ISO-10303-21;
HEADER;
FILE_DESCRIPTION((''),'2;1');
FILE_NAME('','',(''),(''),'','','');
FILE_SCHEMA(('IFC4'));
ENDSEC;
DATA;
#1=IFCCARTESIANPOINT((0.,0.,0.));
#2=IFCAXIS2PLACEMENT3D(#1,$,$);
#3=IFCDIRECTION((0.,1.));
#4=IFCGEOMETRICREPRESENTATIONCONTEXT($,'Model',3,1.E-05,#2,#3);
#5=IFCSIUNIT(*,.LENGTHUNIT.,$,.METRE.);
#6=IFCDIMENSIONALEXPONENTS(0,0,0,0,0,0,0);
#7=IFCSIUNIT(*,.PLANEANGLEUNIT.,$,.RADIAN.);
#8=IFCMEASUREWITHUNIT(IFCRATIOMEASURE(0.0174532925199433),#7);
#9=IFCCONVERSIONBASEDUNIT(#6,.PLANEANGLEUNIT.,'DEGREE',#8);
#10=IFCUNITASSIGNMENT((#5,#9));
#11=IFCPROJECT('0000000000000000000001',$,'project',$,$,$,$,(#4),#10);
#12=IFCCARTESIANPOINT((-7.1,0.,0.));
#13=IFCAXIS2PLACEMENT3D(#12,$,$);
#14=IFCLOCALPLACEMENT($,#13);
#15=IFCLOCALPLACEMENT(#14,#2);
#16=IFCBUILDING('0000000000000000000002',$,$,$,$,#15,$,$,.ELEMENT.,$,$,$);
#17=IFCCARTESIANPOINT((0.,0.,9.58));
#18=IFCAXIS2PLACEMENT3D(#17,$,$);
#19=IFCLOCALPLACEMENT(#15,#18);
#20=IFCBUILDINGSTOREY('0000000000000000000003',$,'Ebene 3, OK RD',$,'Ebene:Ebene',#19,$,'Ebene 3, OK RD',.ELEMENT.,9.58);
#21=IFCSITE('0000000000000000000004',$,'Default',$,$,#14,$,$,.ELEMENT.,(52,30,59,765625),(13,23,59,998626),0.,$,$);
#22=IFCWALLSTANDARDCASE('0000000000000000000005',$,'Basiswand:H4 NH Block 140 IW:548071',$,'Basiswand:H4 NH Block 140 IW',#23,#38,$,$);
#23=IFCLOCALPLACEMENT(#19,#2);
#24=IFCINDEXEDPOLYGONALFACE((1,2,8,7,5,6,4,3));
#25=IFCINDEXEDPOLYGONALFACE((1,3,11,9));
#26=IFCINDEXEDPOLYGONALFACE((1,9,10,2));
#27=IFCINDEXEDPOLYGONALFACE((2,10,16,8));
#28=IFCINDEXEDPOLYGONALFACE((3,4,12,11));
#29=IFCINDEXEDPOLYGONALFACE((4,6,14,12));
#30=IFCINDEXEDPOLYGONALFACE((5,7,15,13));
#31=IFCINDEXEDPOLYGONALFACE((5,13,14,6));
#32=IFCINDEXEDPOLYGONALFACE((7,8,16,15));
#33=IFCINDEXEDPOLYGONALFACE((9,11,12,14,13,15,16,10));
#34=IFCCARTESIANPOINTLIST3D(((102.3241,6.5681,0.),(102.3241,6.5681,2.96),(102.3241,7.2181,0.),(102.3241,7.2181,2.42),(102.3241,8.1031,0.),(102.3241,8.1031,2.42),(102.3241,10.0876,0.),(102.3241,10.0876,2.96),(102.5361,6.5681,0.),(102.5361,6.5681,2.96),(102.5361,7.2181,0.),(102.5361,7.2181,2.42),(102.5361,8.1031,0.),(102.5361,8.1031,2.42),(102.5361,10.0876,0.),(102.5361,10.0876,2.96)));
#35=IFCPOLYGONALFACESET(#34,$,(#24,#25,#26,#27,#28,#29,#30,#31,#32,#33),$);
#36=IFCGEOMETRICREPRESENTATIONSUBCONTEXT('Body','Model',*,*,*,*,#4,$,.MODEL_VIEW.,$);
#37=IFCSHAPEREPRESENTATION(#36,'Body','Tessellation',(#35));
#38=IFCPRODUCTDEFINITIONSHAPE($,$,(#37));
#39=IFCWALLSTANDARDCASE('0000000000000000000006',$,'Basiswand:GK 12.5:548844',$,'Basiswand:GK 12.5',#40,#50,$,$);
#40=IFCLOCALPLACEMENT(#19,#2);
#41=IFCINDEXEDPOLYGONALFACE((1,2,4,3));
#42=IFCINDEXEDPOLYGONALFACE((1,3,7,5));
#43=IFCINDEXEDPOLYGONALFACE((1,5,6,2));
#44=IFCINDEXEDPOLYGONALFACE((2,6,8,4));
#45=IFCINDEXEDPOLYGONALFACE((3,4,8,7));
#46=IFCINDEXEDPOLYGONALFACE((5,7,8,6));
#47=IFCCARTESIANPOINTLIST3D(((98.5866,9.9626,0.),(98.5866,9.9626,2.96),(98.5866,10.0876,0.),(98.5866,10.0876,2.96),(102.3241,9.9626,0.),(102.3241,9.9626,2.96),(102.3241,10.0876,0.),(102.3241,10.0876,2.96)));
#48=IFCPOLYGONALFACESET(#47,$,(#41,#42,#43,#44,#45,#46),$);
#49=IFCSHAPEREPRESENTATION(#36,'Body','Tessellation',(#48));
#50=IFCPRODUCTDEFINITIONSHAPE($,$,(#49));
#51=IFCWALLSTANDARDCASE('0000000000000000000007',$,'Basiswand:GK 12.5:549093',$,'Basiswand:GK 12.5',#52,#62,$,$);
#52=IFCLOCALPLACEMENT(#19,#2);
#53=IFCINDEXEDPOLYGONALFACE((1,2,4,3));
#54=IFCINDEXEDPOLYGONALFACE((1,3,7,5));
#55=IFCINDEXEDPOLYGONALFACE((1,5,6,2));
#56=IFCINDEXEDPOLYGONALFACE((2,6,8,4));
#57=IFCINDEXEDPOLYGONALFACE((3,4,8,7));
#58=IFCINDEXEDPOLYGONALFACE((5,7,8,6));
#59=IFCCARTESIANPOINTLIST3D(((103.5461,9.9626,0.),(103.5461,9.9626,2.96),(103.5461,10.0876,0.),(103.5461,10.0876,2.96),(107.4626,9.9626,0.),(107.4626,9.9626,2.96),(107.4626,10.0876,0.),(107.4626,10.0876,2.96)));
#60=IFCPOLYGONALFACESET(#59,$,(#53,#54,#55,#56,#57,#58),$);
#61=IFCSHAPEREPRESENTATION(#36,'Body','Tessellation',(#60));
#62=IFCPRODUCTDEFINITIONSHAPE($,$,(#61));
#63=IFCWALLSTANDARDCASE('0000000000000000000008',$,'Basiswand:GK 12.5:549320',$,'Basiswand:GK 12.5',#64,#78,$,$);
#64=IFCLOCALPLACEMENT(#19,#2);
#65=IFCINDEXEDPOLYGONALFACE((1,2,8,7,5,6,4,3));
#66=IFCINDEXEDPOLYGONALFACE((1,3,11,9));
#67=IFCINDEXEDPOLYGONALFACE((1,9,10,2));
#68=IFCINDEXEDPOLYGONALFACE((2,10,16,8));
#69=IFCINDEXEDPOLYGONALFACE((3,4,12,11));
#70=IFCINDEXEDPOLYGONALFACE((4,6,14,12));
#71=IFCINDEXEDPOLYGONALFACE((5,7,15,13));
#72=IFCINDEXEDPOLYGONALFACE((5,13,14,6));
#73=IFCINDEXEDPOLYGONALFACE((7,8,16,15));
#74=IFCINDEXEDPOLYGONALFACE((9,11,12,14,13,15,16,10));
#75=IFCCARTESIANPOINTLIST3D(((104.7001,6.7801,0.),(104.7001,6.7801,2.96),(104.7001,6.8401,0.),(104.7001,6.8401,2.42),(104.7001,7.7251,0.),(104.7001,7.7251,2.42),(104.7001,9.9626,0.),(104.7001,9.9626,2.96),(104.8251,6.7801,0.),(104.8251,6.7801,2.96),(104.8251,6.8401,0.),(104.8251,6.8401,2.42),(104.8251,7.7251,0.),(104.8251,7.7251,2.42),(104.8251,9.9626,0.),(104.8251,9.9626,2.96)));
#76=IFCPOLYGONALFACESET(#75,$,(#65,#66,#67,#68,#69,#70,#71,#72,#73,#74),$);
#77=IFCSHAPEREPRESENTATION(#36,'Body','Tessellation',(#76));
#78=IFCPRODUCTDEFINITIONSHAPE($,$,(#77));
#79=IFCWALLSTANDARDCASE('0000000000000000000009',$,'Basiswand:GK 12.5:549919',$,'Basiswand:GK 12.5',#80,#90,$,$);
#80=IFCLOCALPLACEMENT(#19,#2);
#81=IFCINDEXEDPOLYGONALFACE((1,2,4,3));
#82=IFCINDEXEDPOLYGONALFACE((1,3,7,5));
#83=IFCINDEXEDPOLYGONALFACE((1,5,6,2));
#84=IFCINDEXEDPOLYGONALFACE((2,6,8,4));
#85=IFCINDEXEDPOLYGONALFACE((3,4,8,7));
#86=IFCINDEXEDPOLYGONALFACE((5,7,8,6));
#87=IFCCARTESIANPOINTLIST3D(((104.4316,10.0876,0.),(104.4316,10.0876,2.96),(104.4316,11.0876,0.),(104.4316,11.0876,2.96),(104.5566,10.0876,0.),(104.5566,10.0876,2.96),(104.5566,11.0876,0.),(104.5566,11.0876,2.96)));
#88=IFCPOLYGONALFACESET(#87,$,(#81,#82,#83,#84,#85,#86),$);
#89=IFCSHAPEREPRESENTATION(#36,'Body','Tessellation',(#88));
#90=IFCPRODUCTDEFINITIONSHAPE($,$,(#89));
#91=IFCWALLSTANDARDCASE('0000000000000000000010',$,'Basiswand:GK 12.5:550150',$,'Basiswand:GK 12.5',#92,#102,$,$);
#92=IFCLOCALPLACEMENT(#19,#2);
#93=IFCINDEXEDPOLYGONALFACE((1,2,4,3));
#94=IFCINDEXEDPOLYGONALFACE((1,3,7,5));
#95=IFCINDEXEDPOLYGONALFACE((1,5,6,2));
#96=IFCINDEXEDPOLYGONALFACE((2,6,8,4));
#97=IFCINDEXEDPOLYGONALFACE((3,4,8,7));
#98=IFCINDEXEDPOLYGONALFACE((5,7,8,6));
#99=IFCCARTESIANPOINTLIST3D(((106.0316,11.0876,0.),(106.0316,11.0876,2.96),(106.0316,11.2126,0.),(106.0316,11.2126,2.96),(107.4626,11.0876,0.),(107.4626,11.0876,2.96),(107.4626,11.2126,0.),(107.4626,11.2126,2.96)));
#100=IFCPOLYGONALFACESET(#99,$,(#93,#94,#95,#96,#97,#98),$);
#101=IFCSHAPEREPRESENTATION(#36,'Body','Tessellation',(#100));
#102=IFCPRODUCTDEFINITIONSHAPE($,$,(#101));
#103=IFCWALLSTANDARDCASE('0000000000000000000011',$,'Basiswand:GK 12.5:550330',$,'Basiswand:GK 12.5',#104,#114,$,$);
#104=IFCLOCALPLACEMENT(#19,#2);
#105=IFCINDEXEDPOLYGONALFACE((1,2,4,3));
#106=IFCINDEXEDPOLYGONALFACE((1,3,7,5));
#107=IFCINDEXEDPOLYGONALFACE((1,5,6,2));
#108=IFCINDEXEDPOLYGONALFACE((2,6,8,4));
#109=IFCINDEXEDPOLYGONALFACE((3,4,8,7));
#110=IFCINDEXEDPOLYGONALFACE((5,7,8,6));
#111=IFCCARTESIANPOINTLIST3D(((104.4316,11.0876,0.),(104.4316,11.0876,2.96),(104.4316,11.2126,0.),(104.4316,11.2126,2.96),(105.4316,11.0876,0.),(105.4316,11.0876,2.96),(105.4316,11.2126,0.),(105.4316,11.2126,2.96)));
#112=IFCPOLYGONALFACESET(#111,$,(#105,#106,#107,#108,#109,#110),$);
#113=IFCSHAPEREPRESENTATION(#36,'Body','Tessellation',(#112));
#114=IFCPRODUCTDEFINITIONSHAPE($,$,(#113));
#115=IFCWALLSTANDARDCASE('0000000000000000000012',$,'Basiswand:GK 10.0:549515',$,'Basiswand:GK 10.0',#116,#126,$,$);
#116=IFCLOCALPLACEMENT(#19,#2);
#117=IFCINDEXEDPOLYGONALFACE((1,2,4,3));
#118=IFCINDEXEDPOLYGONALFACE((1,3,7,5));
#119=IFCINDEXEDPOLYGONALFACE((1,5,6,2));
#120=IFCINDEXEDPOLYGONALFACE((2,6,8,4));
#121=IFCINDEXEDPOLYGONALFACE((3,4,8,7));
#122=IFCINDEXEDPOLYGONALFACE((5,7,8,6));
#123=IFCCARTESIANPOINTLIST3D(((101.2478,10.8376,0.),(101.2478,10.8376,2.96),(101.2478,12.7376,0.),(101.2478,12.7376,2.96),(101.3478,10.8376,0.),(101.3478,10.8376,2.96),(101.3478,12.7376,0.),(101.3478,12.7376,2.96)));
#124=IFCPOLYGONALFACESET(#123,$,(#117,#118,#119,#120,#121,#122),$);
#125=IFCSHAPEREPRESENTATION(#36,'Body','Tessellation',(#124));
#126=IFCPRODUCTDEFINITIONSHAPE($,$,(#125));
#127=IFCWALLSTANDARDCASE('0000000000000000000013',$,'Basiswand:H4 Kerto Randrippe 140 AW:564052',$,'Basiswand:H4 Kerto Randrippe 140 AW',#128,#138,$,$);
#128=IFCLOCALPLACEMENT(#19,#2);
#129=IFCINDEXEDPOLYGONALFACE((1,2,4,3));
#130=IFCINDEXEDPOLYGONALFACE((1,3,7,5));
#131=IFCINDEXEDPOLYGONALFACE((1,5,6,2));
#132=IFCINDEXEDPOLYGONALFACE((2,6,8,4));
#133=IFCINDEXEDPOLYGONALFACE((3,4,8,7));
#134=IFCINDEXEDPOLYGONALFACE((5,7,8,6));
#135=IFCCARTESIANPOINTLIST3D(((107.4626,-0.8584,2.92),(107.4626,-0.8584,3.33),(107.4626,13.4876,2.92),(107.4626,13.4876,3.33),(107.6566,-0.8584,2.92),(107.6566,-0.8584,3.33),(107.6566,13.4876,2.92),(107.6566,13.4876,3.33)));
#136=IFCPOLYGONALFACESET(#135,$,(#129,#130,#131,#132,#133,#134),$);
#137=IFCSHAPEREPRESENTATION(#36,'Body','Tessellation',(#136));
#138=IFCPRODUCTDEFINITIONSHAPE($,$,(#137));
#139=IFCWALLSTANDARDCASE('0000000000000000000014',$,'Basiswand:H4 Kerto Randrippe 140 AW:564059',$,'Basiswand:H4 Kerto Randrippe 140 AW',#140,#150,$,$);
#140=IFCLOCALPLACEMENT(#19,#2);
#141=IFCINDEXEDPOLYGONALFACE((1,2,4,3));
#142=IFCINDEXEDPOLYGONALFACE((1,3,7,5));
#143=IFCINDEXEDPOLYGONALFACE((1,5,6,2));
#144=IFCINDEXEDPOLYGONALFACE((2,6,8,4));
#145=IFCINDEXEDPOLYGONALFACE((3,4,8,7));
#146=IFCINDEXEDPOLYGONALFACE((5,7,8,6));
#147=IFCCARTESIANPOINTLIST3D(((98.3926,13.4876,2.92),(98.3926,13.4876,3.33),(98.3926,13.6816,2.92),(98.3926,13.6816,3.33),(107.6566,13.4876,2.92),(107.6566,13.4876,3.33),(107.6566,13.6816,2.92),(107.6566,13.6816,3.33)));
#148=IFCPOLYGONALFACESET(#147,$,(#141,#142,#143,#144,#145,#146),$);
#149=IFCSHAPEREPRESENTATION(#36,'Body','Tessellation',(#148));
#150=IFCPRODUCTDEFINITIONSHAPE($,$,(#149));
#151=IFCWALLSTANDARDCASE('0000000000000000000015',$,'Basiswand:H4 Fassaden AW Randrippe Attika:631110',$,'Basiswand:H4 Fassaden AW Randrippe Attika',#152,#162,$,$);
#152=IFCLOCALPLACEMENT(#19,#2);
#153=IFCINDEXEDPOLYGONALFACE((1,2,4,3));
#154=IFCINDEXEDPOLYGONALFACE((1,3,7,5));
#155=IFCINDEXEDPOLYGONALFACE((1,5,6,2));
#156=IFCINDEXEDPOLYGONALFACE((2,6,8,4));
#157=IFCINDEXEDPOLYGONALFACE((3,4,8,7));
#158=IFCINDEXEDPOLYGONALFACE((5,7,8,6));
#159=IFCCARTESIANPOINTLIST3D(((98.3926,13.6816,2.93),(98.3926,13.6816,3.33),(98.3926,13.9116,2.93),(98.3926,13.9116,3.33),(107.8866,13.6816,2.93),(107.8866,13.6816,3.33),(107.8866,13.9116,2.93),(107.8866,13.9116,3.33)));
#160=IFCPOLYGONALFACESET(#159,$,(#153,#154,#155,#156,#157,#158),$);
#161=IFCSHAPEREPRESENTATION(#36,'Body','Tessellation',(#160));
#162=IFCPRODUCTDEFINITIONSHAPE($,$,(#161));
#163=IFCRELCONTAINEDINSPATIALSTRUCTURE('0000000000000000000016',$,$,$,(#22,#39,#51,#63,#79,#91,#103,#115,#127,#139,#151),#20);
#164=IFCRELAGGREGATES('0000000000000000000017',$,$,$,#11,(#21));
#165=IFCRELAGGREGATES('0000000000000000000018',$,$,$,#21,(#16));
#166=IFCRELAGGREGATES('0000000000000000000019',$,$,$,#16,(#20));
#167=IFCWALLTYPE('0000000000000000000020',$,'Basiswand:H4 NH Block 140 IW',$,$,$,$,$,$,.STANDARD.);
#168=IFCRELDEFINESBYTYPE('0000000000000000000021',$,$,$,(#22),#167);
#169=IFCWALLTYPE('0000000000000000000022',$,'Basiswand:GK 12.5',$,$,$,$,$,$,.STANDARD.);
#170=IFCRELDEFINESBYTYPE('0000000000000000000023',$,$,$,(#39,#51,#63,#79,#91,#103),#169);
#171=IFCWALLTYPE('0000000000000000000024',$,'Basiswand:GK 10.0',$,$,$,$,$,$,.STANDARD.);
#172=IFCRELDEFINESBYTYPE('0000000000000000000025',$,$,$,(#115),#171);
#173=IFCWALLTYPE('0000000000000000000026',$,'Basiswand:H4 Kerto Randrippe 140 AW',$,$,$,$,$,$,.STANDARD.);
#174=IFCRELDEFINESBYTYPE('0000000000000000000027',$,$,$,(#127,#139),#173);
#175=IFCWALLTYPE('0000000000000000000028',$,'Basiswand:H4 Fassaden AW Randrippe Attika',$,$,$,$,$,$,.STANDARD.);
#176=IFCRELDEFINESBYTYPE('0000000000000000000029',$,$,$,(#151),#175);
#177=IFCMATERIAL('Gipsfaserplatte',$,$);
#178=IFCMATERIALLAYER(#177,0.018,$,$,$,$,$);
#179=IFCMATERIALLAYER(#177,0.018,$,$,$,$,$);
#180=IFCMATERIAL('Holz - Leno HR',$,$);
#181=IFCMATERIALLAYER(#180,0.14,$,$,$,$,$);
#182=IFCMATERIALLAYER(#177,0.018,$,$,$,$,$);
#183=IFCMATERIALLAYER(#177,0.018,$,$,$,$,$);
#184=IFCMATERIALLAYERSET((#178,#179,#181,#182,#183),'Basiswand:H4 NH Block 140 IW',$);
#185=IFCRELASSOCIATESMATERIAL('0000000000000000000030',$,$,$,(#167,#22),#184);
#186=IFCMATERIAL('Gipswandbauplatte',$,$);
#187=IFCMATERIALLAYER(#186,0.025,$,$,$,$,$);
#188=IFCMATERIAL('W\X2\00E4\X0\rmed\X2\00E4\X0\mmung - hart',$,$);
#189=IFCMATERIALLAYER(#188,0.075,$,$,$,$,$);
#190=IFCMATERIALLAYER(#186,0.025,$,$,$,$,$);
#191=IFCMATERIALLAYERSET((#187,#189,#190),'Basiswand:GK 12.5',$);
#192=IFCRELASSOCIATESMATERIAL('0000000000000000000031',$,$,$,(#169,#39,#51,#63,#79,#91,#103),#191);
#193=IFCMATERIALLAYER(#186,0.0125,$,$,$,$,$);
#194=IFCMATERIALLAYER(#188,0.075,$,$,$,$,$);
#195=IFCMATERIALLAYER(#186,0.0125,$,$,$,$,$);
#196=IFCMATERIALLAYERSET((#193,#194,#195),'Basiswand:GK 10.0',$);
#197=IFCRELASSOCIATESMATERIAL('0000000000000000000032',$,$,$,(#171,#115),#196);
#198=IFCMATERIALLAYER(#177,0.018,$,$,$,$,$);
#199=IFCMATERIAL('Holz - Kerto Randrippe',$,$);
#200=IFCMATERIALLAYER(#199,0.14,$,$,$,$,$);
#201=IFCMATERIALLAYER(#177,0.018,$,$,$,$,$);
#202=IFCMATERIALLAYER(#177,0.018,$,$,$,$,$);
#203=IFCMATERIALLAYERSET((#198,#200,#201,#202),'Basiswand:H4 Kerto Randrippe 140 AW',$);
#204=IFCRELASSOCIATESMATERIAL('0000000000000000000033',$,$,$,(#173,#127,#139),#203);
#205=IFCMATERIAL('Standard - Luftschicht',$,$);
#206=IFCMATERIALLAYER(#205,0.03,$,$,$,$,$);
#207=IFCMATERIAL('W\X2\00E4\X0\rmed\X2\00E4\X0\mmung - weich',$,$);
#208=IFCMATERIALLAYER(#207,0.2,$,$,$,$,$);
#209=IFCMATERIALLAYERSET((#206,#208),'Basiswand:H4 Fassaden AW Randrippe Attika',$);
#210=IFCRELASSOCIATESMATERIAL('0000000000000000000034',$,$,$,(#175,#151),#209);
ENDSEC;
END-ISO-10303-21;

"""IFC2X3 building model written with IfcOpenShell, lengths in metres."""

from ifc_helpers import new_model, entity, si_unit, converted_unit, direction, frame, frame_2d, origin, place, context, subcontext, project, spatial, rectangle, extrude, material, layer, layer_set, layer_usage, type_object, element, save


model = new_model("IFC2X3")

# Units and contexts
model_context = context("Model", 3, precision=1e-05, world=origin(), true_north=direction((0.0, 1.0)))
body_context = subcontext(model_context, "Body", "Model", "MODEL_VIEW")
ifc_project = project(units=[si_unit("LENGTHUNIT", "METRE"), converted_unit("PLANEANGLEUNIT", "DEGREE", entity("IfcRatioMeasure", 0.0174532925199433), si_unit("PLANEANGLEUNIT", "RADIAN"), dimensions=[0, 0, 0, 0, 0, 0, 0])], contexts=[model_context])

# Site, building, storey
site_placement = place(None, frame((-7.1, 0.0, 0.0)))
site = spatial("IfcSite", under=ifc_project, at=site_placement, Name="Default", CompositionType="ELEMENT", RefLatitude=(52, 30, 59, 765625), RefLongitude=(13, 23, 59, 998626), RefElevation=0.0)
building_placement = place(site_placement, origin())
building = spatial("IfcBuilding", under=site, at=building_placement, CompositionType="ELEMENT")
storey_placement = place(building_placement, frame((0.0, 0.0, 9.58)))
storey = spatial("IfcBuildingStorey", under=building, at=storey_placement, Name="Ebene 3, OK RD", ObjectType="Ebene:Ebene", LongName="Ebene 3, OK RD", CompositionType="ELEMENT", Elevation=9.58)

# Shared definitions
ifc_material_1 = material(Name="Gipsfaserplatte")
ifc_material_2 = material(Name="Holz - Leno HR")

# Wall, opening
ifc_layer_1 = layer(ifc_material_1, 0.018)
ifc_layer_2 = layer(ifc_material_1, 0.018)
ifc_layer_3 = layer(ifc_material_2, 0.14)
ifc_layer_4 = layer(ifc_material_1, 0.018)
ifc_layer_5 = layer(ifc_material_1, 0.018)
ifc_layer_set_1 = layer_set([ifc_layer_1, ifc_layer_2, ifc_layer_3, ifc_layer_4, ifc_layer_5], Name="Basiswand:H4 NH Block 140 IW")
ifc_layer_usage_1 = layer_usage(ifc_layer_set_1, "AXIS2", "NEGATIVE", 0.106)
wall_type_1 = type_object("IfcWallType", Name="Basiswand:H4 NH Block 140 IW", PredefinedType="STANDARD", material=ifc_layer_set_1)
wall_1_placement = place(storey_placement, frame((102.4301, 10.0876, 0.0), z_axis=(0.0, 0.0, 1.0), x_axis=(0.0, -1.0, 0.0)))
wall_1 = element("IfcWallStandardCase", 1, at=wall_1_placement, inside=storey, type_object=wall_type_1, material=ifc_layer_usage_1, Name="Basiswand:H4 NH Block 140 IW:548071", ObjectType="Basiswand:H4 NH Block 140 IW", context=body_context, shape_type="SweptSolid", body=[
    extrude(rectangle(XDim=3.5195, YDim=0.212, at=frame_2d((1.7597, 0.0), x_axis=(-1.0, 0.0))), origin(), (0.0, 0.0, 1.0), 2.96),
])
opening_1_placement = place(wall_1_placement, frame((2.8695, 0.106, 0.0)))
element("IfcOpeningElement", 2, at=opening_1_placement, cuts=wall_1, ObjectType="Opening", context=body_context, shape_type="SweptSolid", body=[
    extrude(rectangle(XDim=2.42, YDim=0.885, at=frame_2d((1.21, 0.4425), x_axis=(1.0, 0.0))), frame((0.0, 0.0, 0.0), z_axis=(0.0, -1.0, 0.0), x_axis=(0.0, 0.0, 1.0)), (0.0, 0.0, 1.0), 0.212),
])

# Walls
ifc_material_3 = material(Name="Gipswandbauplatte")
ifc_layer_6 = layer(ifc_material_3, 0.025)
ifc_material_4 = material(Name="Wärmedämmung - hart")
ifc_layer_7 = layer(ifc_material_4, 0.075)
ifc_layer_8 = layer(ifc_material_3, 0.025)
ifc_layer_set_2 = layer_set([ifc_layer_6, ifc_layer_7, ifc_layer_8], Name="Basiswand:GK 12.5")
ifc_layer_usage_2 = layer_usage(ifc_layer_set_2, "AXIS2", "NEGATIVE", 0.0625)
wall_type_2 = type_object("IfcWallType", Name="Basiswand:GK 12.5", PredefinedType="STANDARD", material=ifc_layer_set_2)
wall_2_placement = place(storey_placement, frame((98.5866, 10.0251, 0.0)))
element("IfcWallStandardCase", 3, at=wall_2_placement, inside=storey, type_object=wall_type_2, material=ifc_layer_usage_2, Name="Basiswand:GK 12.5:548844", ObjectType="Basiswand:GK 12.5", context=body_context, shape_type="SweptSolid", body=[
    extrude(rectangle(XDim=3.7375, YDim=0.125, at=frame_2d((1.8687, 0.0), x_axis=(-1.0, 0.0))), origin(), (0.0, 0.0, 1.0), 2.96),
])
ifc_layer_usage_3 = layer_usage(ifc_layer_set_2, "AXIS2", "NEGATIVE", 0.0625)
wall_3_placement = place(storey_placement, frame((103.5461, 10.0251, 0.0)))
element("IfcWallStandardCase", 4, at=wall_3_placement, inside=storey, type_object=wall_type_2, material=ifc_layer_usage_3, Name="Basiswand:GK 12.5:549093", ObjectType="Basiswand:GK 12.5", context=body_context, shape_type="SweptSolid", body=[
    extrude(rectangle(XDim=3.9165, YDim=0.125, at=frame_2d((1.9583, 0.0), x_axis=(-1.0, 0.0))), origin(), (0.0, 0.0, 1.0), 2.96),
])

# Wall, opening
ifc_layer_usage_4 = layer_usage(ifc_layer_set_2, "AXIS2", "NEGATIVE", 0.0625)
wall_4_placement = place(storey_placement, frame((104.7626, 9.9626, 0.0), z_axis=(0.0, 0.0, 1.0), x_axis=(0.0, -1.0, 0.0)))
wall_4 = element("IfcWallStandardCase", 5, at=wall_4_placement, inside=storey, type_object=wall_type_2, material=ifc_layer_usage_4, Name="Basiswand:GK 12.5:549320", ObjectType="Basiswand:GK 12.5", context=body_context, shape_type="SweptSolid", body=[
    extrude(rectangle(XDim=3.1825, YDim=0.125, at=frame_2d((1.5913, 0.0), x_axis=(-1.0, 0.0))), origin(), (0.0, 0.0, 1.0), 2.96),
])
opening_2_placement = place(wall_4_placement, frame((2.2375, -0.0625, 0.0)))
element("IfcOpeningElement", 6, at=opening_2_placement, cuts=wall_4, ObjectType="Opening", context=body_context, shape_type="SweptSolid", body=[
    extrude(rectangle(XDim=2.42, YDim=0.885, at=frame_2d((1.21, 0.4425), x_axis=(1.0, 0.0))), frame((0.0, 0.0, 0.0), z_axis=(0.0, 1.0, 0.0), x_axis=(0.0, 0.0, 1.0)), (0.0, 0.0, 1.0), 0.125),
])

# Walls
ifc_layer_usage_5 = layer_usage(ifc_layer_set_2, "AXIS2", "NEGATIVE", 0.0625)
wall_5_placement = place(storey_placement, frame((104.4941, 11.0876, 0.0), z_axis=(0.0, 0.0, 1.0), x_axis=(0.0, -1.0, 0.0)))
element("IfcWallStandardCase", 7, at=wall_5_placement, inside=storey, type_object=wall_type_2, material=ifc_layer_usage_5, Name="Basiswand:GK 12.5:549919", ObjectType="Basiswand:GK 12.5", context=body_context, shape_type="SweptSolid", body=[
    extrude(rectangle(XDim=1.0, YDim=0.125, at=frame_2d((0.5, 0.0), x_axis=(-1.0, 0.0))), origin(), (0.0, 0.0, 1.0), 2.96),
])
ifc_layer_usage_6 = layer_usage(ifc_layer_set_2, "AXIS2", "NEGATIVE", 0.0625)
wall_6_placement = place(storey_placement, frame((106.0316, 11.1501, 0.0)))
element("IfcWallStandardCase", 8, at=wall_6_placement, inside=storey, type_object=wall_type_2, material=ifc_layer_usage_6, Name="Basiswand:GK 12.5:550150", ObjectType="Basiswand:GK 12.5", context=body_context, shape_type="SweptSolid", body=[
    extrude(rectangle(XDim=1.431, YDim=0.125, at=frame_2d((0.7155, 0.0), x_axis=(-1.0, 0.0))), origin(), (0.0, 0.0, 1.0), 2.96),
])
ifc_layer_usage_7 = layer_usage(ifc_layer_set_2, "AXIS2", "NEGATIVE", 0.0625)
wall_7_placement = place(storey_placement, frame((104.4316, 11.1501, 0.0)))
element("IfcWallStandardCase", 9, at=wall_7_placement, inside=storey, type_object=wall_type_2, material=ifc_layer_usage_7, Name="Basiswand:GK 12.5:550330", ObjectType="Basiswand:GK 12.5", context=body_context, shape_type="SweptSolid", body=[
    extrude(rectangle(XDim=1.0, YDim=0.125, at=frame_2d((0.5, 0.0), x_axis=(-1.0, 0.0))), origin(), (0.0, 0.0, 1.0), 2.96),
])
ifc_layer_9 = layer(ifc_material_3, 0.0125)
ifc_layer_10 = layer(ifc_material_4, 0.075)
ifc_layer_11 = layer(ifc_material_3, 0.0125)
ifc_layer_set_3 = layer_set([ifc_layer_9, ifc_layer_10, ifc_layer_11], Name="Basiswand:GK 10.0")
ifc_layer_usage_8 = layer_usage(ifc_layer_set_3, "AXIS2", "NEGATIVE", 0.05)
wall_type_3 = type_object("IfcWallType", Name="Basiswand:GK 10.0", PredefinedType="STANDARD", material=ifc_layer_set_3)
wall_8_placement = place(storey_placement, frame((101.2978, 12.7376, 0.0), z_axis=(0.0, 0.0, 1.0), x_axis=(0.0, -1.0, 0.0)))
element("IfcWallStandardCase", 10, at=wall_8_placement, inside=storey, type_object=wall_type_3, material=ifc_layer_usage_8, Name="Basiswand:GK 10.0:549515", ObjectType="Basiswand:GK 10.0", context=body_context, shape_type="SweptSolid", body=[
    extrude(rectangle(XDim=1.9, YDim=0.1, at=frame_2d((0.95, 0.0), x_axis=(-1.0, 0.0))), origin(), (0.0, 0.0, 1.0), 2.96),
])
ifc_layer_12 = layer(ifc_material_1, 0.018)
ifc_material_5 = material(Name="Holz - Kerto Randrippe")
ifc_layer_13 = layer(ifc_material_5, 0.14)
ifc_layer_14 = layer(ifc_material_1, 0.018)
ifc_layer_15 = layer(ifc_material_1, 0.018)
ifc_layer_set_4 = layer_set([ifc_layer_12, ifc_layer_13, ifc_layer_14, ifc_layer_15], Name="Basiswand:H4 Kerto Randrippe 140 AW")
ifc_layer_usage_9 = layer_usage(ifc_layer_set_4, "AXIS2", "NEGATIVE", 0.097)
wall_type_4 = type_object("IfcWallType", Name="Basiswand:H4 Kerto Randrippe 140 AW", PredefinedType="STANDARD", material=ifc_layer_set_4)
wall_9_placement = place(storey_placement, frame((107.5596, 13.4876, 2.92), z_axis=(0.0, 0.0, 1.0), x_axis=(0.0, -1.0, 0.0)))
element("IfcWallStandardCase", 11, at=wall_9_placement, inside=storey, type_object=wall_type_4, material=ifc_layer_usage_9, Name="Basiswand:H4 Kerto Randrippe 140 AW:564052", ObjectType="Basiswand:H4 Kerto Randrippe 140 AW", context=body_context, shape_type="SweptSolid", body=[
    extrude(rectangle(XDim=14.346, YDim=0.194, at=frame_2d((7.173, 0.0), x_axis=(-1.0, 0.0))), origin(), (0.0, 0.0, 1.0), 0.41),
])
ifc_layer_usage_10 = layer_usage(ifc_layer_set_4, "AXIS2", "NEGATIVE", 0.097)
wall_10_placement = place(storey_placement, frame((98.3926, 13.5846, 2.92)))
element("IfcWallStandardCase", 12, at=wall_10_placement, inside=storey, type_object=wall_type_4, material=ifc_layer_usage_10, Name="Basiswand:H4 Kerto Randrippe 140 AW:564059", ObjectType="Basiswand:H4 Kerto Randrippe 140 AW", context=body_context, shape_type="SweptSolid", body=[
    extrude(rectangle(XDim=9.264, YDim=0.194, at=frame_2d((4.632, 0.0), x_axis=(-1.0, 0.0))), origin(), (0.0, 0.0, 1.0), 0.41),
])
ifc_material_6 = material(Name="Standard - Luftschicht")
ifc_layer_16 = layer(ifc_material_6, 0.03)
ifc_material_7 = material(Name="Wärmedämmung - weich")
ifc_layer_17 = layer(ifc_material_7, 0.2)
ifc_layer_set_5 = layer_set([ifc_layer_16, ifc_layer_17], Name="Basiswand:H4 Fassaden AW Randrippe Attika")
ifc_layer_usage_11 = layer_usage(ifc_layer_set_5, "AXIS2", "NEGATIVE", 0.115)
wall_type_5 = type_object("IfcWallType", Name="Basiswand:H4 Fassaden AW Randrippe Attika", PredefinedType="STANDARD", material=ifc_layer_set_5)
wall_11_placement = place(storey_placement, frame((98.3926, 13.7966, 2.93)))
element("IfcWallStandardCase", 13, at=wall_11_placement, inside=storey, type_object=wall_type_5, material=ifc_layer_usage_11, Name="Basiswand:H4 Fassaden AW Randrippe Attika:631110", ObjectType="Basiswand:H4 Fassaden AW Randrippe Attika", context=body_context, shape_type="SweptSolid", body=[
    extrude(rectangle(XDim=9.494, YDim=0.23, at=frame_2d((4.747, 0.0), x_axis=(-1.0, 0.0))), origin(), (0.0, 0.0, 1.0), 0.4),
])

save(model, "model.ifc")
